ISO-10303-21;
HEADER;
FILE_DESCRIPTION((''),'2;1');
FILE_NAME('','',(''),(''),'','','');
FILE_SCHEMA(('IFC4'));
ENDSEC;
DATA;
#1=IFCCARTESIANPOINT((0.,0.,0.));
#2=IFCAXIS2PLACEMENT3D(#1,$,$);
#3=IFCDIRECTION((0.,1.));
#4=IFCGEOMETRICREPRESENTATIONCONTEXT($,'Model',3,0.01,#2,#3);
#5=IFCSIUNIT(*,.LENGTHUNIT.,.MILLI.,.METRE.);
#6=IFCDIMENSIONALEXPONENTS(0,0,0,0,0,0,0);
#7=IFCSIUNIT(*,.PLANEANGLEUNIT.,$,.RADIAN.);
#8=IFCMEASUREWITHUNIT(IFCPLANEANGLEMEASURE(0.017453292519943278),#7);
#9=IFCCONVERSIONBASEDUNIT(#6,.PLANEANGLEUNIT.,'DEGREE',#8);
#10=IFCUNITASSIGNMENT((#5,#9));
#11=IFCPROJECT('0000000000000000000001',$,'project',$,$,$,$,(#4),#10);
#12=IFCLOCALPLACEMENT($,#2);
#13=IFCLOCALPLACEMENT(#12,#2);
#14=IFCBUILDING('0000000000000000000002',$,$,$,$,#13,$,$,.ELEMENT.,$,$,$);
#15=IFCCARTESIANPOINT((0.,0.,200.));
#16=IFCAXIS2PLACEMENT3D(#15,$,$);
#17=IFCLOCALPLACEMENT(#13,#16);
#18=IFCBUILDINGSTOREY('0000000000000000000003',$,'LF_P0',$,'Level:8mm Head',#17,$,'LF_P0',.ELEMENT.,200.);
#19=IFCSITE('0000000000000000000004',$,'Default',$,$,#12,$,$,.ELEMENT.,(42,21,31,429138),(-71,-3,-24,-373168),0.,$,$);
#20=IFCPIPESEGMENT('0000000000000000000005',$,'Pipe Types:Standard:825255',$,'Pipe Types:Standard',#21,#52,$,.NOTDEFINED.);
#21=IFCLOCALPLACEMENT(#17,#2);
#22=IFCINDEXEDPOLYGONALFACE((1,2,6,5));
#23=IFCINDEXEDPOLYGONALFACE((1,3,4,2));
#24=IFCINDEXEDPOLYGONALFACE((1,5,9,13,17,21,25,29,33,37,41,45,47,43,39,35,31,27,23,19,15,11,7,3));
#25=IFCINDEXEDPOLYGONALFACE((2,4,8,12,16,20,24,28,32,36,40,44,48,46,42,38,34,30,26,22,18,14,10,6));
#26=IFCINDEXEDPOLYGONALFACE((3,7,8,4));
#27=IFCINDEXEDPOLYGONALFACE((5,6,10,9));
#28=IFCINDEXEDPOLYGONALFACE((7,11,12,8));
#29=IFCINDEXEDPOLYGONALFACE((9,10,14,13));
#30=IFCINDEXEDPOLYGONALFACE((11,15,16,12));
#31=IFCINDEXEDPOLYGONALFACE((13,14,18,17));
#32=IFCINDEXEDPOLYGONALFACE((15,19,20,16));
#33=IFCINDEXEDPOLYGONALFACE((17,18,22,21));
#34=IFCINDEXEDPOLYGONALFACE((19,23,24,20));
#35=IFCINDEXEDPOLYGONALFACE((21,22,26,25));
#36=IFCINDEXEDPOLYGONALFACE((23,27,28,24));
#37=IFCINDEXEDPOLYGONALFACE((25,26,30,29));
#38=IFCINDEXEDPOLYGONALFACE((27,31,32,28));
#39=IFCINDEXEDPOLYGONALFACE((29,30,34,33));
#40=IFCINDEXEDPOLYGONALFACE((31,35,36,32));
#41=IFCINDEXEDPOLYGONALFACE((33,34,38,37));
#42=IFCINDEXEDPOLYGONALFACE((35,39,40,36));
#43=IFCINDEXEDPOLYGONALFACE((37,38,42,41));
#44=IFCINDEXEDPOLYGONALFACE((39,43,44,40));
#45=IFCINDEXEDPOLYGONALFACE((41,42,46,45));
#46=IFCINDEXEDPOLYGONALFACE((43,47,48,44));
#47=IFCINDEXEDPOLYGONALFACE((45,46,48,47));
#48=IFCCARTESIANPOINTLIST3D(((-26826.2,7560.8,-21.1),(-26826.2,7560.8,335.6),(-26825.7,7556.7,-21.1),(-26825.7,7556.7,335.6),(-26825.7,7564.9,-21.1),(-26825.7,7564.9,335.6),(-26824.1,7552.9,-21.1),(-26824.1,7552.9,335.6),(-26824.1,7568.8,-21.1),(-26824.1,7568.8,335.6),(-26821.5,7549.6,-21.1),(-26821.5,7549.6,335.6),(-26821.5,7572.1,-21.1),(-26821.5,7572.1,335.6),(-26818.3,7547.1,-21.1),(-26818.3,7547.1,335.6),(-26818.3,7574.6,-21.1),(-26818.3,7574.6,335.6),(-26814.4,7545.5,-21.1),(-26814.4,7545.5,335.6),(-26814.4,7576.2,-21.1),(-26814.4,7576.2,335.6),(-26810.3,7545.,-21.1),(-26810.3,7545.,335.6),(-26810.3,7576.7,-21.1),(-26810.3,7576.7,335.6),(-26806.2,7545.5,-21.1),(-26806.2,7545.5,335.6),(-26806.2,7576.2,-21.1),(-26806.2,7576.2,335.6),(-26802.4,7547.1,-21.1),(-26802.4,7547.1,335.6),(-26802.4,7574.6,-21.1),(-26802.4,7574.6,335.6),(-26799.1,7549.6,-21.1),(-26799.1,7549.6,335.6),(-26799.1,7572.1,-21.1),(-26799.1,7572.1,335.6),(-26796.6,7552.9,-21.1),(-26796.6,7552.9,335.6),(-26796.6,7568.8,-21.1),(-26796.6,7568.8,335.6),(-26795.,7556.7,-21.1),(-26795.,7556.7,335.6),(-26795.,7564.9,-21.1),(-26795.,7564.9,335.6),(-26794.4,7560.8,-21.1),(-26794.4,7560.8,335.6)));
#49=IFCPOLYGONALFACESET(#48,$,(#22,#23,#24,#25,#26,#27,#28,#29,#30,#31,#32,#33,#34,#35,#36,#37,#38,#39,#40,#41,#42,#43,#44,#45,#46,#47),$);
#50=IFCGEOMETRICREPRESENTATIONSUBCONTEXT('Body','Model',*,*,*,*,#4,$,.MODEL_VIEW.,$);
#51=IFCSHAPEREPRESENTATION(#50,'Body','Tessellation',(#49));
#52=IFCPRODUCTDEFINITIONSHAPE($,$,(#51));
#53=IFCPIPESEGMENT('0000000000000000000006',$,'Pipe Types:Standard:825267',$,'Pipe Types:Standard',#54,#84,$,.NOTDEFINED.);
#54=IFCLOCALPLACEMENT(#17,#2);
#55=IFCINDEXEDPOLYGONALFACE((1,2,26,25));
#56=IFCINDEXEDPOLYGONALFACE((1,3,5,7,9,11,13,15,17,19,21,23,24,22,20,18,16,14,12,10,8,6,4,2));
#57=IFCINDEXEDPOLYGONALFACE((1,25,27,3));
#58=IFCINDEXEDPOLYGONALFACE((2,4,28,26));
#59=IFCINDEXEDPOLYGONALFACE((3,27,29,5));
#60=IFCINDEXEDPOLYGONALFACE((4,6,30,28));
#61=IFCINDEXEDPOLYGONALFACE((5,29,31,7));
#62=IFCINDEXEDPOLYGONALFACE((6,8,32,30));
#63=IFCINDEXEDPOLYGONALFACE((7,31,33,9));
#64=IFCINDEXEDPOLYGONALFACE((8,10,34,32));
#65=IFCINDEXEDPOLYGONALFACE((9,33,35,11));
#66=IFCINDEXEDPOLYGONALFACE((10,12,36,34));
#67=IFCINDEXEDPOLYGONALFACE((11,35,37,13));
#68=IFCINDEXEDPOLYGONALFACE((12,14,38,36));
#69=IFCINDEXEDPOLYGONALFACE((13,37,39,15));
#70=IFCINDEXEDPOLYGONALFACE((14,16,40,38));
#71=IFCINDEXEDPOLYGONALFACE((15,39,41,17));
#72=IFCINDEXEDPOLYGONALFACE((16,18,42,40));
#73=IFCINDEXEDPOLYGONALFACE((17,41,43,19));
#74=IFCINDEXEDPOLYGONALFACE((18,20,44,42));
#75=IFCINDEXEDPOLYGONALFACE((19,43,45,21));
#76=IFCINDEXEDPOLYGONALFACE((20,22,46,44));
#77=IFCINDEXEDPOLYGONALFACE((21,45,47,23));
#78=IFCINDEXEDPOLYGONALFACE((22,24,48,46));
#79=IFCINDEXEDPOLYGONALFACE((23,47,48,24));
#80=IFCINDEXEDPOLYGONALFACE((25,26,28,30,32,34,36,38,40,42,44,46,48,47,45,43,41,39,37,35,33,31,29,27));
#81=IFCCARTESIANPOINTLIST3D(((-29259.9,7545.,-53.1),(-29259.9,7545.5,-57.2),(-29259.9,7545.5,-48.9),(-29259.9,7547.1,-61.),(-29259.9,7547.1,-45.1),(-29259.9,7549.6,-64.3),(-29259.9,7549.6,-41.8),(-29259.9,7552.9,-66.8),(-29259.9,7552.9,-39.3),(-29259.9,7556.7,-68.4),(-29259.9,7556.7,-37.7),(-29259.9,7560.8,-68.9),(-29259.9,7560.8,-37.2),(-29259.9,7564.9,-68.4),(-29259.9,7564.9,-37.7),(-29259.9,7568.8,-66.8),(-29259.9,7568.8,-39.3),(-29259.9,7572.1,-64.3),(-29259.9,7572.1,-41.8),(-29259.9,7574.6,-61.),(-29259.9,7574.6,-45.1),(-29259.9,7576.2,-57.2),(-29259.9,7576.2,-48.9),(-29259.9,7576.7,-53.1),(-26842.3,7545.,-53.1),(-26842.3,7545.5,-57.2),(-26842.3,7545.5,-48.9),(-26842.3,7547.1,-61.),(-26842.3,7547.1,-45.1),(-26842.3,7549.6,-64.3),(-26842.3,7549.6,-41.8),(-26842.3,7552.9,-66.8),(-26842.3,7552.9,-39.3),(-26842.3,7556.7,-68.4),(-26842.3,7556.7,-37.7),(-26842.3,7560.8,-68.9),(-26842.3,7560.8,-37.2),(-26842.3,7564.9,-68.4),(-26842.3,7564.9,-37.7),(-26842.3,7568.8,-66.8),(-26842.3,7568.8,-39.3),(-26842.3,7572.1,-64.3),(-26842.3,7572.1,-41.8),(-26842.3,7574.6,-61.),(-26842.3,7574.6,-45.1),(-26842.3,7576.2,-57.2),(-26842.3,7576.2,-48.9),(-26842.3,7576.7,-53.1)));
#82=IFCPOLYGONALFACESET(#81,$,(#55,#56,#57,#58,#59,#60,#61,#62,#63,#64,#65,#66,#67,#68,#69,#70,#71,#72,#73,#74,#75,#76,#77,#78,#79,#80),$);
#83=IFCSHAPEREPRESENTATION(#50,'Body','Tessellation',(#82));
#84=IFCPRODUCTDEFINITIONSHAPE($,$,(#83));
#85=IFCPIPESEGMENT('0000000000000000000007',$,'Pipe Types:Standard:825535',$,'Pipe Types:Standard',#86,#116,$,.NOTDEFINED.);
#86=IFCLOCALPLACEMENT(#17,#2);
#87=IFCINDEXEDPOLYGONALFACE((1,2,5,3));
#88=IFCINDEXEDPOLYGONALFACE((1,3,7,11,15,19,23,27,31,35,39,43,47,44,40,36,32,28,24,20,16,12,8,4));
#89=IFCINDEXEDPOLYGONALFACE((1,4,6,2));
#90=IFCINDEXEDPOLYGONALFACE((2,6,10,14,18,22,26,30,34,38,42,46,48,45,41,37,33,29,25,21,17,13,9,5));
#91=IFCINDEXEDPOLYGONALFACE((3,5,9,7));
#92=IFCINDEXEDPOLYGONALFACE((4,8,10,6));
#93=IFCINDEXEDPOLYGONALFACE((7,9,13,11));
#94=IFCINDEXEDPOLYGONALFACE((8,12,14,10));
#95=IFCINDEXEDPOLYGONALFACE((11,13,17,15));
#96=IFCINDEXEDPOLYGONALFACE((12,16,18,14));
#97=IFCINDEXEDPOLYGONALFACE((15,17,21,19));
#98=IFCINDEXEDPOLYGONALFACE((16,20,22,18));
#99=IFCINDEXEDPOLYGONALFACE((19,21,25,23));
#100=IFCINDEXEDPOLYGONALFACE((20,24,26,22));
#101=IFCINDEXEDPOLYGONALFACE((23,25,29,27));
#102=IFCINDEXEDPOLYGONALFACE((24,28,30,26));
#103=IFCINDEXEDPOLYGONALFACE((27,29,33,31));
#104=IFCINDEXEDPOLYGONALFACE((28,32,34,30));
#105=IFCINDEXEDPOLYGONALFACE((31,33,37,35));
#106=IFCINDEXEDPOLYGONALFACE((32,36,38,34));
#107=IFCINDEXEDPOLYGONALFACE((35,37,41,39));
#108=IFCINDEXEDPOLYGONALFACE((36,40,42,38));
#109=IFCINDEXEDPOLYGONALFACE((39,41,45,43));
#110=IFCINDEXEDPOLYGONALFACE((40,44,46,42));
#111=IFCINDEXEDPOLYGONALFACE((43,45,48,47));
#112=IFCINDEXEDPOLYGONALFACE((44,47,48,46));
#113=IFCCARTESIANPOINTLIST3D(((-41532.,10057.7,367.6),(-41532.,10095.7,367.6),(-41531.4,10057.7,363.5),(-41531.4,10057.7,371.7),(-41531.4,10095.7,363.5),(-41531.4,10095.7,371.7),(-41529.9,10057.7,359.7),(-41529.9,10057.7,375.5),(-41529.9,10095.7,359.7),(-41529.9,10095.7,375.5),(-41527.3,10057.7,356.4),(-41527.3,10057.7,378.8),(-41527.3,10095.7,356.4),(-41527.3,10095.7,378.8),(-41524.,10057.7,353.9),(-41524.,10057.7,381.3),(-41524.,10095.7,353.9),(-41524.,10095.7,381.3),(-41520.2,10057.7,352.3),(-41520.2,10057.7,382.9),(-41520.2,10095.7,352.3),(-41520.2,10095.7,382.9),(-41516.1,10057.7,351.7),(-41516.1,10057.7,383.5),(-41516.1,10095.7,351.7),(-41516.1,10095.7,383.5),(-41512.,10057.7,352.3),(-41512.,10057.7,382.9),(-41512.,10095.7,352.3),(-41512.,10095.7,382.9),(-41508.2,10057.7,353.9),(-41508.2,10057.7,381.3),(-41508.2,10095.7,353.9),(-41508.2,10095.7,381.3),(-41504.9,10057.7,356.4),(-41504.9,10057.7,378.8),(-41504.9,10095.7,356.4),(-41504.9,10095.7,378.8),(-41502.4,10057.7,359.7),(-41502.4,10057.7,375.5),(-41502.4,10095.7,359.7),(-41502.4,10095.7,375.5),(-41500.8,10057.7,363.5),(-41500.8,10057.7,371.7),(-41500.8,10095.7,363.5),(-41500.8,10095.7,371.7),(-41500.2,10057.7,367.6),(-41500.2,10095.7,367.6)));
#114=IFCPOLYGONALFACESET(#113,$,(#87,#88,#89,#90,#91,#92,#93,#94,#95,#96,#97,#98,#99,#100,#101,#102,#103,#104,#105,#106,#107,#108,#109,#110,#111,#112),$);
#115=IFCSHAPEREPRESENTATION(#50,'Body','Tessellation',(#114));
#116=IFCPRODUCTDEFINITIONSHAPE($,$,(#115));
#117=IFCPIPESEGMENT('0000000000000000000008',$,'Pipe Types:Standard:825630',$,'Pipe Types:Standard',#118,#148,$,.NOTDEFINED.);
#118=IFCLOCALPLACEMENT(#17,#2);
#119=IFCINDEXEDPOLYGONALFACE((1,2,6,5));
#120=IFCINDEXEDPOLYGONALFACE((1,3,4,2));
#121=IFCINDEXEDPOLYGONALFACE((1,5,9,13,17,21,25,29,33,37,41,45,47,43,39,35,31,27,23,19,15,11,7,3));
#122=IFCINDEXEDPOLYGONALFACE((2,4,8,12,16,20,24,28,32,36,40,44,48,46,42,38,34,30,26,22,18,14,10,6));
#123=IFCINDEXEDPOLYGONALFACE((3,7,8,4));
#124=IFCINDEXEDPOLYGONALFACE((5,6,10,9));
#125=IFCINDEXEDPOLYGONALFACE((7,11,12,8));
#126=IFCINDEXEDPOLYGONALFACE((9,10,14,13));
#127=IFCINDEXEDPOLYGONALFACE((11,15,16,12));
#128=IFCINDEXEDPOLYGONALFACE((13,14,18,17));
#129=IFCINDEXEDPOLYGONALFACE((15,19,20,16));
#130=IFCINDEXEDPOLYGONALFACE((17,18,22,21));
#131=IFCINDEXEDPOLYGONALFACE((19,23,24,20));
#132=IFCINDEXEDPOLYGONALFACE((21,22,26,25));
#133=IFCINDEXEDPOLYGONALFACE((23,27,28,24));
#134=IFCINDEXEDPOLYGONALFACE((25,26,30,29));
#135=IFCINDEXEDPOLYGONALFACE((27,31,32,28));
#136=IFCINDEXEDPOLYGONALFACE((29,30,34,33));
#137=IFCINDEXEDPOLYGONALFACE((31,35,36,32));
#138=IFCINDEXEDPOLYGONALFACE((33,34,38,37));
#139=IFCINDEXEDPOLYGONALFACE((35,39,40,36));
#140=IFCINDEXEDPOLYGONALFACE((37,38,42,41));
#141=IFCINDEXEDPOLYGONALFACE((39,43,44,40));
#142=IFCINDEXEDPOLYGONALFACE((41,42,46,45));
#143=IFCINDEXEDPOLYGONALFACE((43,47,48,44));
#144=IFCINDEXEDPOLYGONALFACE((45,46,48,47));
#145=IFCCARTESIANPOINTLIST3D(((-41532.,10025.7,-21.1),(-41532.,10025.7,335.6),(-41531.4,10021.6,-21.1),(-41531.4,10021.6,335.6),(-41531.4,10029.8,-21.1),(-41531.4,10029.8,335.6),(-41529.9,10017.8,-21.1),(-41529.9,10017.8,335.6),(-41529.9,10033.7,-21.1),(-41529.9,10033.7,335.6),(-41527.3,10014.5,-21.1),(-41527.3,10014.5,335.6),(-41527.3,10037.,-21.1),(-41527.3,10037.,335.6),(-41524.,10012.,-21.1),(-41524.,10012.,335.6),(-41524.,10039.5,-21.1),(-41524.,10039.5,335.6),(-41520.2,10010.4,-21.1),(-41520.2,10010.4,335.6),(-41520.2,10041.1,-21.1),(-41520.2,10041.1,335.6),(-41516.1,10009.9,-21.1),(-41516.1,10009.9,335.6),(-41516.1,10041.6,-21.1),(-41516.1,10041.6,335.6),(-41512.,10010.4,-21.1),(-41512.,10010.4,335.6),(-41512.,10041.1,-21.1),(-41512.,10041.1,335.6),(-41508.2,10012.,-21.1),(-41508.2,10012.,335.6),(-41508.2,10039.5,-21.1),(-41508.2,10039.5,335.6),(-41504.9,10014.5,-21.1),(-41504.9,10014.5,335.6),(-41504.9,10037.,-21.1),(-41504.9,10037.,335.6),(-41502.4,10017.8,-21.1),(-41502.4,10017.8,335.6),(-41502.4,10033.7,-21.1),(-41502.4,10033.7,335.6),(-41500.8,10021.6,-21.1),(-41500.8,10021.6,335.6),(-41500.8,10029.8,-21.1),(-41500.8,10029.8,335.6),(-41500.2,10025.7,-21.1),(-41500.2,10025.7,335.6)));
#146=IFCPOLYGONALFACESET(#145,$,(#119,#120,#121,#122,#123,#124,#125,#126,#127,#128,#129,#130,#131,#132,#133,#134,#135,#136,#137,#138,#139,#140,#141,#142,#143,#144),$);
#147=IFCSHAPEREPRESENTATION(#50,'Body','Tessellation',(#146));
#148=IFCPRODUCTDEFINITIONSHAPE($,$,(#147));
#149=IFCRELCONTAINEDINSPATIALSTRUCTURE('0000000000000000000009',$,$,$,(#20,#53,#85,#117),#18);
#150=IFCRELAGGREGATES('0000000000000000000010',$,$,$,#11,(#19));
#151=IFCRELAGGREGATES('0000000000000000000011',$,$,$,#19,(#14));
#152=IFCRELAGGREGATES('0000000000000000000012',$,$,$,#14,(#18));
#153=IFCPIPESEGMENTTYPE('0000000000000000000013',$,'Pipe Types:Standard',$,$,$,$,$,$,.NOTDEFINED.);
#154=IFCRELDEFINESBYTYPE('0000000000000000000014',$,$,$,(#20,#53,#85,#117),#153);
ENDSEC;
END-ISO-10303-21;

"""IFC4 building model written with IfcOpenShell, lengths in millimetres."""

from ifc_helpers import new_model, entity, si_unit, converted_unit, direction, frame, origin, place, context, subcontext, project, spatial, arc, indexed_curve, outline, extrude, type_object, element, save


model = new_model("IFC4")

# Units and contexts
model_context = context("Model", 3, precision=0.01, world=origin(), true_north=direction((0.0, 1.0)))
body_context = subcontext(model_context, "Body", "Model", "MODEL_VIEW")
ifc_project = project(units=[si_unit("LENGTHUNIT", "METRE", prefix="MILLI"), converted_unit("PLANEANGLEUNIT", "DEGREE", entity("IfcPlaneAngleMeasure", 0.017453292519943278), si_unit("PLANEANGLEUNIT", "RADIAN"), dimensions=[0, 0, 0, 0, 0, 0, 0])], contexts=[model_context])

# Site, building, storey
site_placement = place(None, origin())
site = spatial("IfcSite", under=ifc_project, at=site_placement, Name="Default", CompositionType="ELEMENT", RefLatitude=(42, 21, 31, 429138), RefLongitude=(-71, -3, -24, -373168), RefElevation=0.0)
building_placement = place(site_placement, origin())
building = spatial("IfcBuilding", under=site, at=building_placement, CompositionType="ELEMENT")
storey_placement = place(building_placement, frame((0.0, 0.0, 200.0)))
storey = spatial("IfcBuildingStorey", under=building, at=storey_placement, Name="LF_P0", ObjectType="Level:8mm Head", LongName="LF_P0", CompositionType="ELEMENT", Elevation=200.0)

# Pipe segments
pipe_segment_type_1 = type_object("IfcPipeSegmentType", Name="Pipe Types:Standard", PredefinedType="NOTDEFINED")
pipe_segment_1_placement = place(storey_placement, origin())
element("IfcPipeSegment", 1, at=pipe_segment_1_placement, inside=storey, type_object=pipe_segment_type_1, Name="Pipe Types:Standard:825255", ObjectType="Pipe Types:Standard", PredefinedType="NOTDEFINED", context=body_context, shape_type="SweptSolid", body=[
    extrude(outline(indexed_curve([(15.9, 0.0), (11.2, 11.2), (0.0, 15.9), (-11.2, 11.2), (-15.9, 0.0), (-11.2, -11.2), (0.0, -15.9), (11.2, -11.2)], segments=[arc(1, 2, 3), arc(3, 4, 5), arc(5, 6, 7), arc(7, 8, 1)], self_intersect=False)), frame((-26810.3, 7560.8, -21.1)), (0.0, 0.0, 1.0), 356.7),
])
pipe_segment_2_placement = place(storey_placement, origin())
element("IfcPipeSegment", 2, at=pipe_segment_2_placement, inside=storey, type_object=pipe_segment_type_1, Name="Pipe Types:Standard:825267", ObjectType="Pipe Types:Standard", PredefinedType="NOTDEFINED", context=body_context, shape_type="SweptSolid", body=[
    extrude(outline(indexed_curve([(15.9, 0.0), (11.2, 11.2), (0.0, 15.9), (-11.2, 11.2), (-15.9, 0.0), (-11.2, -11.2), (0.0, -15.9), (11.2, -11.2)], segments=[arc(1, 2, 3), arc(3, 4, 5), arc(5, 6, 7), arc(7, 8, 1)], self_intersect=False)), frame((-29259.9, 7560.8, -53.1), z_axis=(1.0, 0.0, 0.0), x_axis=(0.0, 1.0, 0.0)), (0.0, 0.0, 1.0), 2417.6),
])
pipe_segment_3_placement = place(storey_placement, origin())
element("IfcPipeSegment", 3, at=pipe_segment_3_placement, inside=storey, type_object=pipe_segment_type_1, Name="Pipe Types:Standard:825535", ObjectType="Pipe Types:Standard", PredefinedType="NOTDEFINED", context=body_context, shape_type="SweptSolid", body=[
    extrude(outline(indexed_curve([(15.9, 0.0), (11.2, 11.2), (0.0, 15.9), (-11.2, 11.2), (-15.9, 0.0), (-11.2, -11.2), (0.0, -15.9), (11.2, -11.2)], segments=[arc(1, 2, 3), arc(3, 4, 5), arc(5, 6, 7), arc(7, 8, 1)], self_intersect=False)), frame((-41516.1, 10057.7, 367.6), z_axis=(0.0, 1.0, 0.0), x_axis=(-1.0, 0.0, 0.0)), (0.0, 0.0, 1.0), 37.9),
])
pipe_segment_4_placement = place(storey_placement, origin())
element("IfcPipeSegment", 4, at=pipe_segment_4_placement, inside=storey, type_object=pipe_segment_type_1, Name="Pipe Types:Standard:825630", ObjectType="Pipe Types:Standard", PredefinedType="NOTDEFINED", context=body_context, shape_type="SweptSolid", body=[
    extrude(outline(indexed_curve([(15.9, 0.0), (11.2, 11.2), (0.0, 15.9), (-11.2, 11.2), (-15.9, 0.0), (-11.2, -11.2), (0.0, -15.9), (11.2, -11.2)], segments=[arc(1, 2, 3), arc(3, 4, 5), arc(5, 6, 7), arc(7, 8, 1)], self_intersect=False)), frame((-41516.1, 10025.7, -21.1)), (0.0, 0.0, 1.0), 356.7),
])

save(model, "model.ifc")
